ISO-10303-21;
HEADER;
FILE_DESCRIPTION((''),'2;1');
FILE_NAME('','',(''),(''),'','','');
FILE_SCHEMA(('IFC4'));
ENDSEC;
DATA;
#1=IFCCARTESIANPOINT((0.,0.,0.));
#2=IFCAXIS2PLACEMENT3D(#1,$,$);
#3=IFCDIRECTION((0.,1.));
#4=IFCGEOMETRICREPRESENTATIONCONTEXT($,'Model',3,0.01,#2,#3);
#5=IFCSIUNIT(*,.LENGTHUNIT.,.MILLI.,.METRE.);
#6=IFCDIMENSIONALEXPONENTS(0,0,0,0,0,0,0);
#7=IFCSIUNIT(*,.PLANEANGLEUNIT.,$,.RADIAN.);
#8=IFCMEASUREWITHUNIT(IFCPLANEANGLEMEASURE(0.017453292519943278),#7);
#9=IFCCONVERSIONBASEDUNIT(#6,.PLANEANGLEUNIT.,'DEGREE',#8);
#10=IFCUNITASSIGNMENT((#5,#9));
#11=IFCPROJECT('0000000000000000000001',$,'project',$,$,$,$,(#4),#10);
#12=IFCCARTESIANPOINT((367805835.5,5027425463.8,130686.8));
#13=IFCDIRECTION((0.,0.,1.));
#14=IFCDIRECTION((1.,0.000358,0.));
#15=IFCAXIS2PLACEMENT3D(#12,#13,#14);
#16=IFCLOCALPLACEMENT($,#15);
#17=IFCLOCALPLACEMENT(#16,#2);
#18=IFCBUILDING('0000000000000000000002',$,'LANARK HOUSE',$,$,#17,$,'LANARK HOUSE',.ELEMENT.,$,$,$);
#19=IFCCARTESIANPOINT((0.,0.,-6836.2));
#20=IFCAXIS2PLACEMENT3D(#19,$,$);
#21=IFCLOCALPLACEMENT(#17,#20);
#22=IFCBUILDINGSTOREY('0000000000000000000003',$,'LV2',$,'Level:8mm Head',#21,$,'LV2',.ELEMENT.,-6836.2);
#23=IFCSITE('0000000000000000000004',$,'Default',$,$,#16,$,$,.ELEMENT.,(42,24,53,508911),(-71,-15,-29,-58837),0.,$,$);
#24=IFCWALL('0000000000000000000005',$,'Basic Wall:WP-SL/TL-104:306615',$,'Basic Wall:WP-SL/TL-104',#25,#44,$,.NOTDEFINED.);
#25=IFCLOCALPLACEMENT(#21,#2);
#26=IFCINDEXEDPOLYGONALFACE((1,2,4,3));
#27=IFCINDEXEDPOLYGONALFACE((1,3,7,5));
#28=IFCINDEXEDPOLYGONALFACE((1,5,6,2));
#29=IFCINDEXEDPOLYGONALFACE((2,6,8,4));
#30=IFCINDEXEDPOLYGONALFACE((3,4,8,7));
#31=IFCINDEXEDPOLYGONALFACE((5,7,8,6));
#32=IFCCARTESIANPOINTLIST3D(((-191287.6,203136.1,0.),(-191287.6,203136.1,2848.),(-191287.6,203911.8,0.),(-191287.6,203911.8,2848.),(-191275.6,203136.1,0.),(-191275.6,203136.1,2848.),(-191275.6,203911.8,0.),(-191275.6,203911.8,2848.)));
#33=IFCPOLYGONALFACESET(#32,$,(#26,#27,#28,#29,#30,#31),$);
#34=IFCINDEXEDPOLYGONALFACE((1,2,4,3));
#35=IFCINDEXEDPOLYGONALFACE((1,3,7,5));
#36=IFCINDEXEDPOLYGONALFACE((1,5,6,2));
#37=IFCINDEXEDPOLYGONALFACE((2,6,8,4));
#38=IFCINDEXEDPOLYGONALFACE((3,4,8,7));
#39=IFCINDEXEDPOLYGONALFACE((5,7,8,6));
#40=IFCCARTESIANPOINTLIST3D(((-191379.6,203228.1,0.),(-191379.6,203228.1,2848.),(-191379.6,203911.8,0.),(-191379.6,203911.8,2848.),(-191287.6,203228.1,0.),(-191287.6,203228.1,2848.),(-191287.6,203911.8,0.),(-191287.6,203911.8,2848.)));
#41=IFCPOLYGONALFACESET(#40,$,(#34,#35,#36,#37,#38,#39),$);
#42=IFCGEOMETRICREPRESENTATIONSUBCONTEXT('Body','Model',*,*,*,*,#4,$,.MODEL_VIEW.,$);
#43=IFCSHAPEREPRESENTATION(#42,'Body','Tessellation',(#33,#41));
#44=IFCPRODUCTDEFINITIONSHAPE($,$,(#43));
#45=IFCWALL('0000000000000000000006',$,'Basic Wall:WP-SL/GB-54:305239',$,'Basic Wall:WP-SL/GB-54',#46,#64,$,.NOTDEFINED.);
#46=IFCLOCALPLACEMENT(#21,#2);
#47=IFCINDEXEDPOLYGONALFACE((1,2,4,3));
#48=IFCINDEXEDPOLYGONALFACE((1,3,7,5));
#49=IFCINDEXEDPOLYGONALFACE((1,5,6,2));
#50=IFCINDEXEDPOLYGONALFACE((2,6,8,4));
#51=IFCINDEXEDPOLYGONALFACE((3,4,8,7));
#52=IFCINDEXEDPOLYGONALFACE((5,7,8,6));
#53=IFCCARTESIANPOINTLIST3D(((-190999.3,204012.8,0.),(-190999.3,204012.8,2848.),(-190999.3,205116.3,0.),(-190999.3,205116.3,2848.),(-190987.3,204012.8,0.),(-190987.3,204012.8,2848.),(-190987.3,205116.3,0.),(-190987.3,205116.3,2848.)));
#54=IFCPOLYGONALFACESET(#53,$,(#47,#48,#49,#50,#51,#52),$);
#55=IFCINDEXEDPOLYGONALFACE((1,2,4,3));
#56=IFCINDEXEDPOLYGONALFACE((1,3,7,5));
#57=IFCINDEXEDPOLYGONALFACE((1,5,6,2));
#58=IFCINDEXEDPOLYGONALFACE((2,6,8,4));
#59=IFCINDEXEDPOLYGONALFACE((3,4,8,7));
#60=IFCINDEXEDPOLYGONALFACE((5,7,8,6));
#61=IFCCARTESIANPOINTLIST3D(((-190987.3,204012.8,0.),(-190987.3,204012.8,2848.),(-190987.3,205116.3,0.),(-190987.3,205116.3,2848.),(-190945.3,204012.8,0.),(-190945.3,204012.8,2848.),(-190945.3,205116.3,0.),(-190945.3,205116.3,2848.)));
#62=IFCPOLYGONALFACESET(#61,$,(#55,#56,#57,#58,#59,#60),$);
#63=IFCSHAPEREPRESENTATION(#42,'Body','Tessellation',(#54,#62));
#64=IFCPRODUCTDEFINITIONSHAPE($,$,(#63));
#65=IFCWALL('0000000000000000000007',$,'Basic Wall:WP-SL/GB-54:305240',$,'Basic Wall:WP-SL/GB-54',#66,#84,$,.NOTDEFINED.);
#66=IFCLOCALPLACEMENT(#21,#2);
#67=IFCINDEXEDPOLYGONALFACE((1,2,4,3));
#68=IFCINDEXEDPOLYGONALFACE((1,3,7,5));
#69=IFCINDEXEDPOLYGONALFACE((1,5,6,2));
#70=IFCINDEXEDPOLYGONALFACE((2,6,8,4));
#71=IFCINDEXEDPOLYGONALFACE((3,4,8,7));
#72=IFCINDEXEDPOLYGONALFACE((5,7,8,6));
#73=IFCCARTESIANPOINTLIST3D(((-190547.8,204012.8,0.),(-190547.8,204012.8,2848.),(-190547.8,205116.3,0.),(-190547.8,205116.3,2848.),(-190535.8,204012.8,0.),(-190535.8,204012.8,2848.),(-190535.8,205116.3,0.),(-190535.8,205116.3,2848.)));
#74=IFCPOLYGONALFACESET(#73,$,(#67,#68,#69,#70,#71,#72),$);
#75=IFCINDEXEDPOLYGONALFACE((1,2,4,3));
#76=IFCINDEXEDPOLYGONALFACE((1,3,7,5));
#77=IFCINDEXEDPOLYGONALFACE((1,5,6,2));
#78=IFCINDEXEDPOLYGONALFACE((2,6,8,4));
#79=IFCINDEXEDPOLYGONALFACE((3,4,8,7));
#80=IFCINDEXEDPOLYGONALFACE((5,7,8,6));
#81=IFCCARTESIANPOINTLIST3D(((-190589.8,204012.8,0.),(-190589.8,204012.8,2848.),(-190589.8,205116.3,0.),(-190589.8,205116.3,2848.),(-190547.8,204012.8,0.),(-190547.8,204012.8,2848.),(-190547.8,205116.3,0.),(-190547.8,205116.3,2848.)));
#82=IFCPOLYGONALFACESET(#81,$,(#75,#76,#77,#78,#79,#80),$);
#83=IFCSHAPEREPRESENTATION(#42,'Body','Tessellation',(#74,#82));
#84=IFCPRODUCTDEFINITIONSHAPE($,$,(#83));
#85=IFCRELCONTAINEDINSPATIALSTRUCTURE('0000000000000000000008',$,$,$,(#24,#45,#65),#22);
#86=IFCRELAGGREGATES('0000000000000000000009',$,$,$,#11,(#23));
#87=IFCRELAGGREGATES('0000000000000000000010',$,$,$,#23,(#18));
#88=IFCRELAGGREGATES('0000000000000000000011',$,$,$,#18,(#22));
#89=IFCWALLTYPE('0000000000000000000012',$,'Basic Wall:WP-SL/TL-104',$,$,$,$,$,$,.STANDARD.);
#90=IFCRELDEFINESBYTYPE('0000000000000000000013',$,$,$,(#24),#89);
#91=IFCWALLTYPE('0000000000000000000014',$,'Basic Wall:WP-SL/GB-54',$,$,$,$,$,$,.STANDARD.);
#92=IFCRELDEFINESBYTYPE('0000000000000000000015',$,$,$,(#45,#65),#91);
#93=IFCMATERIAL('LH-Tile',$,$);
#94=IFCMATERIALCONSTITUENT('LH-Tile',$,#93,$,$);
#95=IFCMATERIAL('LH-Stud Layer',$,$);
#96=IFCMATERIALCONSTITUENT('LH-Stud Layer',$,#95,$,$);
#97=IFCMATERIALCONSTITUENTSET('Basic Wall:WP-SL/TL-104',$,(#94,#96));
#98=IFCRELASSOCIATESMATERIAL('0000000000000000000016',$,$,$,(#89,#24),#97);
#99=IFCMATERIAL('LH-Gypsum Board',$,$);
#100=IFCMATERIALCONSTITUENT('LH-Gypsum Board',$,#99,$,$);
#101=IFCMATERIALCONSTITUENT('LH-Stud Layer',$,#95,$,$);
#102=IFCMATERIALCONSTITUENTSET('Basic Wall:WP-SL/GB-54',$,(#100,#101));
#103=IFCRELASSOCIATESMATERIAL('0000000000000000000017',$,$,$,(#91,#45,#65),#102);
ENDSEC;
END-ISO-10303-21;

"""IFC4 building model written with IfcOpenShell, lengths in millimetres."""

from ifc_helpers import new_model, entity, si_unit, converted_unit, direction, frame, origin, place, context, subcontext, project, spatial, indexed_curve, outline, extrude, material, constituent, constituent_set, type_object, element, save


model = new_model("IFC4")

# Units and contexts
model_context = context("Model", 3, precision=0.01, world=origin(), true_north=direction((0.0, 1.0)))
body_context = subcontext(model_context, "Body", "Model", "MODEL_VIEW")
ifc_project = project(units=[si_unit("LENGTHUNIT", "METRE", prefix="MILLI"), converted_unit("PLANEANGLEUNIT", "DEGREE", entity("IfcPlaneAngleMeasure", 0.017453292519943278), si_unit("PLANEANGLEUNIT", "RADIAN"), dimensions=[0, 0, 0, 0, 0, 0, 0])], contexts=[model_context])

# Site, building, storey
site_placement = place(None, frame((367805835.5, 5027425463.8, 130686.8), z_axis=(0.0, 0.0, 1.0), x_axis=(1.0, 0.000358, 0.0)))
site = spatial("IfcSite", under=ifc_project, at=site_placement, Name="Default", CompositionType="ELEMENT", RefLatitude=(42, 24, 53, 508911), RefLongitude=(-71, -15, -29, -58837), RefElevation=0.0)
building_placement = place(site_placement, origin())
building = spatial("IfcBuilding", under=site, at=building_placement, Name="LANARK HOUSE", LongName="LANARK HOUSE", CompositionType="ELEMENT")
storey_placement = place(building_placement, frame((0.0, 0.0, -6836.2)))
storey = spatial("IfcBuildingStorey", under=building, at=storey_placement, Name="LV2", ObjectType="Level:8mm Head", LongName="LV2", CompositionType="ELEMENT", Elevation=-6836.2)

# Shared definitions
ifc_material_1 = material(Name="LH-Gypsum Board")
ifc_material_2 = material(Name="LH-Stud Layer")

# Walls
ifc_material_3 = material(Name="LH-Tile")
ifc_constituent_1 = constituent(ifc_material_3, Name="LH-Tile")
ifc_constituent_2 = constituent(ifc_material_2, Name="LH-Stud Layer")
ifc_constituent_set_1 = constituent_set(constituents=[ifc_constituent_1, ifc_constituent_2], Name="Basic Wall:WP-SL/TL-104")
wall_type_1 = type_object("IfcWallType", Name="Basic Wall:WP-SL/TL-104", PredefinedType="STANDARD", material=ifc_constituent_set_1)
wall_1_placement = place(storey_placement, frame((-191327.6, 203911.8, 0.0), z_axis=(0.0, 0.0, 1.0), x_axis=(0.0, -1.0, 0.0)))
element("IfcWall", 1, at=wall_1_placement, inside=storey, type_object=wall_type_1, material=ifc_constituent_set_1, Name="Basic Wall:WP-SL/TL-104:306615", ObjectType="Basic Wall:WP-SL/TL-104", PredefinedType="NOTDEFINED", context=body_context, shape_type="SweptSolid", body=[
    extrude(outline(indexed_curve([(-6.0, -387.8), (6.0, -387.8), (6.0, 387.8), (-6.0, 387.8), (-6.0, -387.8)], self_intersect=False)), frame((387.8, 46.0, 0.0), z_axis=(0.0, 0.0, 1.0), x_axis=(0.0, -1.0, 0.0)), (0.0, 0.0, 1.0), 2848.0),
    extrude(outline(indexed_curve([(-46.0, -341.8), (46.0, -341.8), (46.0, 341.8), (-46.0, 341.8), (-46.0, -341.8)], self_intersect=False)), frame((341.8, -6.0, 0.0), z_axis=(0.0, 0.0, 1.0), x_axis=(0.0, 1.0, 0.0)), (0.0, 0.0, 1.0), 2848.0),
])
ifc_constituent_3 = constituent(ifc_material_1, Name="LH-Gypsum Board")
ifc_constituent_4 = constituent(ifc_material_2, Name="LH-Stud Layer")
ifc_constituent_set_2 = constituent_set(constituents=[ifc_constituent_3, ifc_constituent_4], Name="Basic Wall:WP-SL/GB-54")
wall_type_2 = type_object("IfcWallType", Name="Basic Wall:WP-SL/GB-54", PredefinedType="STANDARD", material=ifc_constituent_set_2)
wall_2_placement = place(storey_placement, frame((-190972.3, 204012.8, 0.0), z_axis=(0.0, 0.0, 1.0), x_axis=(0.0, 1.0, 0.0)))
element("IfcWall", 2, at=wall_2_placement, inside=storey, type_object=wall_type_2, material=ifc_constituent_set_2, Name="Basic Wall:WP-SL/GB-54:305239", ObjectType="Basic Wall:WP-SL/GB-54", PredefinedType="NOTDEFINED", context=body_context, shape_type="SweptSolid", body=[
    extrude(outline(indexed_curve([(-6.0, -551.8), (6.0, -551.8), (6.0, 551.8), (-6.0, 551.8), (-6.0, -551.8)], self_intersect=False)), frame((551.8, 21.0, 0.0), z_axis=(0.0, 0.0, 1.0), x_axis=(0.0, -1.0, 0.0)), (0.0, 0.0, 1.0), 2848.0),
    extrude(outline(indexed_curve([(-21.0, -551.8), (21.0, -551.8), (21.0, 551.8), (-21.0, 551.8), (-21.0, -551.8)], self_intersect=False)), frame((551.8, -6.0, 0.0), z_axis=(0.0, 0.0, 1.0), x_axis=(0.0, 1.0, 0.0)), (0.0, 0.0, 1.0), 2848.0),
])
wall_3_placement = place(storey_placement, frame((-190562.8, 205116.3, 0.0), z_axis=(0.0, 0.0, 1.0), x_axis=(0.0, -1.0, 0.0)))
element("IfcWall", 3, at=wall_3_placement, inside=storey, type_object=wall_type_2, material=ifc_constituent_set_2, Name="Basic Wall:WP-SL/GB-54:305240", ObjectType="Basic Wall:WP-SL/GB-54", PredefinedType="NOTDEFINED", context=body_context, shape_type="SweptSolid", body=[
    extrude(outline(indexed_curve([(-6.0, -551.8), (6.0, -551.8), (6.0, 551.8), (-6.0, 551.8), (-6.0, -551.8)], self_intersect=False)), frame((551.8, 21.0, 0.0), z_axis=(0.0, 0.0, 1.0), x_axis=(0.0, -1.0, 0.0)), (0.0, 0.0, 1.0), 2848.0),
    extrude(outline(indexed_curve([(-21.0, -551.8), (21.0, -551.8), (21.0, 551.8), (-21.0, 551.8), (-21.0, -551.8)], self_intersect=False)), frame((551.8, -6.0, 0.0), z_axis=(0.0, 0.0, 1.0), x_axis=(0.0, 1.0, 0.0)), (0.0, 0.0, 1.0), 2848.0),
])

save(model, "model.ifc")
